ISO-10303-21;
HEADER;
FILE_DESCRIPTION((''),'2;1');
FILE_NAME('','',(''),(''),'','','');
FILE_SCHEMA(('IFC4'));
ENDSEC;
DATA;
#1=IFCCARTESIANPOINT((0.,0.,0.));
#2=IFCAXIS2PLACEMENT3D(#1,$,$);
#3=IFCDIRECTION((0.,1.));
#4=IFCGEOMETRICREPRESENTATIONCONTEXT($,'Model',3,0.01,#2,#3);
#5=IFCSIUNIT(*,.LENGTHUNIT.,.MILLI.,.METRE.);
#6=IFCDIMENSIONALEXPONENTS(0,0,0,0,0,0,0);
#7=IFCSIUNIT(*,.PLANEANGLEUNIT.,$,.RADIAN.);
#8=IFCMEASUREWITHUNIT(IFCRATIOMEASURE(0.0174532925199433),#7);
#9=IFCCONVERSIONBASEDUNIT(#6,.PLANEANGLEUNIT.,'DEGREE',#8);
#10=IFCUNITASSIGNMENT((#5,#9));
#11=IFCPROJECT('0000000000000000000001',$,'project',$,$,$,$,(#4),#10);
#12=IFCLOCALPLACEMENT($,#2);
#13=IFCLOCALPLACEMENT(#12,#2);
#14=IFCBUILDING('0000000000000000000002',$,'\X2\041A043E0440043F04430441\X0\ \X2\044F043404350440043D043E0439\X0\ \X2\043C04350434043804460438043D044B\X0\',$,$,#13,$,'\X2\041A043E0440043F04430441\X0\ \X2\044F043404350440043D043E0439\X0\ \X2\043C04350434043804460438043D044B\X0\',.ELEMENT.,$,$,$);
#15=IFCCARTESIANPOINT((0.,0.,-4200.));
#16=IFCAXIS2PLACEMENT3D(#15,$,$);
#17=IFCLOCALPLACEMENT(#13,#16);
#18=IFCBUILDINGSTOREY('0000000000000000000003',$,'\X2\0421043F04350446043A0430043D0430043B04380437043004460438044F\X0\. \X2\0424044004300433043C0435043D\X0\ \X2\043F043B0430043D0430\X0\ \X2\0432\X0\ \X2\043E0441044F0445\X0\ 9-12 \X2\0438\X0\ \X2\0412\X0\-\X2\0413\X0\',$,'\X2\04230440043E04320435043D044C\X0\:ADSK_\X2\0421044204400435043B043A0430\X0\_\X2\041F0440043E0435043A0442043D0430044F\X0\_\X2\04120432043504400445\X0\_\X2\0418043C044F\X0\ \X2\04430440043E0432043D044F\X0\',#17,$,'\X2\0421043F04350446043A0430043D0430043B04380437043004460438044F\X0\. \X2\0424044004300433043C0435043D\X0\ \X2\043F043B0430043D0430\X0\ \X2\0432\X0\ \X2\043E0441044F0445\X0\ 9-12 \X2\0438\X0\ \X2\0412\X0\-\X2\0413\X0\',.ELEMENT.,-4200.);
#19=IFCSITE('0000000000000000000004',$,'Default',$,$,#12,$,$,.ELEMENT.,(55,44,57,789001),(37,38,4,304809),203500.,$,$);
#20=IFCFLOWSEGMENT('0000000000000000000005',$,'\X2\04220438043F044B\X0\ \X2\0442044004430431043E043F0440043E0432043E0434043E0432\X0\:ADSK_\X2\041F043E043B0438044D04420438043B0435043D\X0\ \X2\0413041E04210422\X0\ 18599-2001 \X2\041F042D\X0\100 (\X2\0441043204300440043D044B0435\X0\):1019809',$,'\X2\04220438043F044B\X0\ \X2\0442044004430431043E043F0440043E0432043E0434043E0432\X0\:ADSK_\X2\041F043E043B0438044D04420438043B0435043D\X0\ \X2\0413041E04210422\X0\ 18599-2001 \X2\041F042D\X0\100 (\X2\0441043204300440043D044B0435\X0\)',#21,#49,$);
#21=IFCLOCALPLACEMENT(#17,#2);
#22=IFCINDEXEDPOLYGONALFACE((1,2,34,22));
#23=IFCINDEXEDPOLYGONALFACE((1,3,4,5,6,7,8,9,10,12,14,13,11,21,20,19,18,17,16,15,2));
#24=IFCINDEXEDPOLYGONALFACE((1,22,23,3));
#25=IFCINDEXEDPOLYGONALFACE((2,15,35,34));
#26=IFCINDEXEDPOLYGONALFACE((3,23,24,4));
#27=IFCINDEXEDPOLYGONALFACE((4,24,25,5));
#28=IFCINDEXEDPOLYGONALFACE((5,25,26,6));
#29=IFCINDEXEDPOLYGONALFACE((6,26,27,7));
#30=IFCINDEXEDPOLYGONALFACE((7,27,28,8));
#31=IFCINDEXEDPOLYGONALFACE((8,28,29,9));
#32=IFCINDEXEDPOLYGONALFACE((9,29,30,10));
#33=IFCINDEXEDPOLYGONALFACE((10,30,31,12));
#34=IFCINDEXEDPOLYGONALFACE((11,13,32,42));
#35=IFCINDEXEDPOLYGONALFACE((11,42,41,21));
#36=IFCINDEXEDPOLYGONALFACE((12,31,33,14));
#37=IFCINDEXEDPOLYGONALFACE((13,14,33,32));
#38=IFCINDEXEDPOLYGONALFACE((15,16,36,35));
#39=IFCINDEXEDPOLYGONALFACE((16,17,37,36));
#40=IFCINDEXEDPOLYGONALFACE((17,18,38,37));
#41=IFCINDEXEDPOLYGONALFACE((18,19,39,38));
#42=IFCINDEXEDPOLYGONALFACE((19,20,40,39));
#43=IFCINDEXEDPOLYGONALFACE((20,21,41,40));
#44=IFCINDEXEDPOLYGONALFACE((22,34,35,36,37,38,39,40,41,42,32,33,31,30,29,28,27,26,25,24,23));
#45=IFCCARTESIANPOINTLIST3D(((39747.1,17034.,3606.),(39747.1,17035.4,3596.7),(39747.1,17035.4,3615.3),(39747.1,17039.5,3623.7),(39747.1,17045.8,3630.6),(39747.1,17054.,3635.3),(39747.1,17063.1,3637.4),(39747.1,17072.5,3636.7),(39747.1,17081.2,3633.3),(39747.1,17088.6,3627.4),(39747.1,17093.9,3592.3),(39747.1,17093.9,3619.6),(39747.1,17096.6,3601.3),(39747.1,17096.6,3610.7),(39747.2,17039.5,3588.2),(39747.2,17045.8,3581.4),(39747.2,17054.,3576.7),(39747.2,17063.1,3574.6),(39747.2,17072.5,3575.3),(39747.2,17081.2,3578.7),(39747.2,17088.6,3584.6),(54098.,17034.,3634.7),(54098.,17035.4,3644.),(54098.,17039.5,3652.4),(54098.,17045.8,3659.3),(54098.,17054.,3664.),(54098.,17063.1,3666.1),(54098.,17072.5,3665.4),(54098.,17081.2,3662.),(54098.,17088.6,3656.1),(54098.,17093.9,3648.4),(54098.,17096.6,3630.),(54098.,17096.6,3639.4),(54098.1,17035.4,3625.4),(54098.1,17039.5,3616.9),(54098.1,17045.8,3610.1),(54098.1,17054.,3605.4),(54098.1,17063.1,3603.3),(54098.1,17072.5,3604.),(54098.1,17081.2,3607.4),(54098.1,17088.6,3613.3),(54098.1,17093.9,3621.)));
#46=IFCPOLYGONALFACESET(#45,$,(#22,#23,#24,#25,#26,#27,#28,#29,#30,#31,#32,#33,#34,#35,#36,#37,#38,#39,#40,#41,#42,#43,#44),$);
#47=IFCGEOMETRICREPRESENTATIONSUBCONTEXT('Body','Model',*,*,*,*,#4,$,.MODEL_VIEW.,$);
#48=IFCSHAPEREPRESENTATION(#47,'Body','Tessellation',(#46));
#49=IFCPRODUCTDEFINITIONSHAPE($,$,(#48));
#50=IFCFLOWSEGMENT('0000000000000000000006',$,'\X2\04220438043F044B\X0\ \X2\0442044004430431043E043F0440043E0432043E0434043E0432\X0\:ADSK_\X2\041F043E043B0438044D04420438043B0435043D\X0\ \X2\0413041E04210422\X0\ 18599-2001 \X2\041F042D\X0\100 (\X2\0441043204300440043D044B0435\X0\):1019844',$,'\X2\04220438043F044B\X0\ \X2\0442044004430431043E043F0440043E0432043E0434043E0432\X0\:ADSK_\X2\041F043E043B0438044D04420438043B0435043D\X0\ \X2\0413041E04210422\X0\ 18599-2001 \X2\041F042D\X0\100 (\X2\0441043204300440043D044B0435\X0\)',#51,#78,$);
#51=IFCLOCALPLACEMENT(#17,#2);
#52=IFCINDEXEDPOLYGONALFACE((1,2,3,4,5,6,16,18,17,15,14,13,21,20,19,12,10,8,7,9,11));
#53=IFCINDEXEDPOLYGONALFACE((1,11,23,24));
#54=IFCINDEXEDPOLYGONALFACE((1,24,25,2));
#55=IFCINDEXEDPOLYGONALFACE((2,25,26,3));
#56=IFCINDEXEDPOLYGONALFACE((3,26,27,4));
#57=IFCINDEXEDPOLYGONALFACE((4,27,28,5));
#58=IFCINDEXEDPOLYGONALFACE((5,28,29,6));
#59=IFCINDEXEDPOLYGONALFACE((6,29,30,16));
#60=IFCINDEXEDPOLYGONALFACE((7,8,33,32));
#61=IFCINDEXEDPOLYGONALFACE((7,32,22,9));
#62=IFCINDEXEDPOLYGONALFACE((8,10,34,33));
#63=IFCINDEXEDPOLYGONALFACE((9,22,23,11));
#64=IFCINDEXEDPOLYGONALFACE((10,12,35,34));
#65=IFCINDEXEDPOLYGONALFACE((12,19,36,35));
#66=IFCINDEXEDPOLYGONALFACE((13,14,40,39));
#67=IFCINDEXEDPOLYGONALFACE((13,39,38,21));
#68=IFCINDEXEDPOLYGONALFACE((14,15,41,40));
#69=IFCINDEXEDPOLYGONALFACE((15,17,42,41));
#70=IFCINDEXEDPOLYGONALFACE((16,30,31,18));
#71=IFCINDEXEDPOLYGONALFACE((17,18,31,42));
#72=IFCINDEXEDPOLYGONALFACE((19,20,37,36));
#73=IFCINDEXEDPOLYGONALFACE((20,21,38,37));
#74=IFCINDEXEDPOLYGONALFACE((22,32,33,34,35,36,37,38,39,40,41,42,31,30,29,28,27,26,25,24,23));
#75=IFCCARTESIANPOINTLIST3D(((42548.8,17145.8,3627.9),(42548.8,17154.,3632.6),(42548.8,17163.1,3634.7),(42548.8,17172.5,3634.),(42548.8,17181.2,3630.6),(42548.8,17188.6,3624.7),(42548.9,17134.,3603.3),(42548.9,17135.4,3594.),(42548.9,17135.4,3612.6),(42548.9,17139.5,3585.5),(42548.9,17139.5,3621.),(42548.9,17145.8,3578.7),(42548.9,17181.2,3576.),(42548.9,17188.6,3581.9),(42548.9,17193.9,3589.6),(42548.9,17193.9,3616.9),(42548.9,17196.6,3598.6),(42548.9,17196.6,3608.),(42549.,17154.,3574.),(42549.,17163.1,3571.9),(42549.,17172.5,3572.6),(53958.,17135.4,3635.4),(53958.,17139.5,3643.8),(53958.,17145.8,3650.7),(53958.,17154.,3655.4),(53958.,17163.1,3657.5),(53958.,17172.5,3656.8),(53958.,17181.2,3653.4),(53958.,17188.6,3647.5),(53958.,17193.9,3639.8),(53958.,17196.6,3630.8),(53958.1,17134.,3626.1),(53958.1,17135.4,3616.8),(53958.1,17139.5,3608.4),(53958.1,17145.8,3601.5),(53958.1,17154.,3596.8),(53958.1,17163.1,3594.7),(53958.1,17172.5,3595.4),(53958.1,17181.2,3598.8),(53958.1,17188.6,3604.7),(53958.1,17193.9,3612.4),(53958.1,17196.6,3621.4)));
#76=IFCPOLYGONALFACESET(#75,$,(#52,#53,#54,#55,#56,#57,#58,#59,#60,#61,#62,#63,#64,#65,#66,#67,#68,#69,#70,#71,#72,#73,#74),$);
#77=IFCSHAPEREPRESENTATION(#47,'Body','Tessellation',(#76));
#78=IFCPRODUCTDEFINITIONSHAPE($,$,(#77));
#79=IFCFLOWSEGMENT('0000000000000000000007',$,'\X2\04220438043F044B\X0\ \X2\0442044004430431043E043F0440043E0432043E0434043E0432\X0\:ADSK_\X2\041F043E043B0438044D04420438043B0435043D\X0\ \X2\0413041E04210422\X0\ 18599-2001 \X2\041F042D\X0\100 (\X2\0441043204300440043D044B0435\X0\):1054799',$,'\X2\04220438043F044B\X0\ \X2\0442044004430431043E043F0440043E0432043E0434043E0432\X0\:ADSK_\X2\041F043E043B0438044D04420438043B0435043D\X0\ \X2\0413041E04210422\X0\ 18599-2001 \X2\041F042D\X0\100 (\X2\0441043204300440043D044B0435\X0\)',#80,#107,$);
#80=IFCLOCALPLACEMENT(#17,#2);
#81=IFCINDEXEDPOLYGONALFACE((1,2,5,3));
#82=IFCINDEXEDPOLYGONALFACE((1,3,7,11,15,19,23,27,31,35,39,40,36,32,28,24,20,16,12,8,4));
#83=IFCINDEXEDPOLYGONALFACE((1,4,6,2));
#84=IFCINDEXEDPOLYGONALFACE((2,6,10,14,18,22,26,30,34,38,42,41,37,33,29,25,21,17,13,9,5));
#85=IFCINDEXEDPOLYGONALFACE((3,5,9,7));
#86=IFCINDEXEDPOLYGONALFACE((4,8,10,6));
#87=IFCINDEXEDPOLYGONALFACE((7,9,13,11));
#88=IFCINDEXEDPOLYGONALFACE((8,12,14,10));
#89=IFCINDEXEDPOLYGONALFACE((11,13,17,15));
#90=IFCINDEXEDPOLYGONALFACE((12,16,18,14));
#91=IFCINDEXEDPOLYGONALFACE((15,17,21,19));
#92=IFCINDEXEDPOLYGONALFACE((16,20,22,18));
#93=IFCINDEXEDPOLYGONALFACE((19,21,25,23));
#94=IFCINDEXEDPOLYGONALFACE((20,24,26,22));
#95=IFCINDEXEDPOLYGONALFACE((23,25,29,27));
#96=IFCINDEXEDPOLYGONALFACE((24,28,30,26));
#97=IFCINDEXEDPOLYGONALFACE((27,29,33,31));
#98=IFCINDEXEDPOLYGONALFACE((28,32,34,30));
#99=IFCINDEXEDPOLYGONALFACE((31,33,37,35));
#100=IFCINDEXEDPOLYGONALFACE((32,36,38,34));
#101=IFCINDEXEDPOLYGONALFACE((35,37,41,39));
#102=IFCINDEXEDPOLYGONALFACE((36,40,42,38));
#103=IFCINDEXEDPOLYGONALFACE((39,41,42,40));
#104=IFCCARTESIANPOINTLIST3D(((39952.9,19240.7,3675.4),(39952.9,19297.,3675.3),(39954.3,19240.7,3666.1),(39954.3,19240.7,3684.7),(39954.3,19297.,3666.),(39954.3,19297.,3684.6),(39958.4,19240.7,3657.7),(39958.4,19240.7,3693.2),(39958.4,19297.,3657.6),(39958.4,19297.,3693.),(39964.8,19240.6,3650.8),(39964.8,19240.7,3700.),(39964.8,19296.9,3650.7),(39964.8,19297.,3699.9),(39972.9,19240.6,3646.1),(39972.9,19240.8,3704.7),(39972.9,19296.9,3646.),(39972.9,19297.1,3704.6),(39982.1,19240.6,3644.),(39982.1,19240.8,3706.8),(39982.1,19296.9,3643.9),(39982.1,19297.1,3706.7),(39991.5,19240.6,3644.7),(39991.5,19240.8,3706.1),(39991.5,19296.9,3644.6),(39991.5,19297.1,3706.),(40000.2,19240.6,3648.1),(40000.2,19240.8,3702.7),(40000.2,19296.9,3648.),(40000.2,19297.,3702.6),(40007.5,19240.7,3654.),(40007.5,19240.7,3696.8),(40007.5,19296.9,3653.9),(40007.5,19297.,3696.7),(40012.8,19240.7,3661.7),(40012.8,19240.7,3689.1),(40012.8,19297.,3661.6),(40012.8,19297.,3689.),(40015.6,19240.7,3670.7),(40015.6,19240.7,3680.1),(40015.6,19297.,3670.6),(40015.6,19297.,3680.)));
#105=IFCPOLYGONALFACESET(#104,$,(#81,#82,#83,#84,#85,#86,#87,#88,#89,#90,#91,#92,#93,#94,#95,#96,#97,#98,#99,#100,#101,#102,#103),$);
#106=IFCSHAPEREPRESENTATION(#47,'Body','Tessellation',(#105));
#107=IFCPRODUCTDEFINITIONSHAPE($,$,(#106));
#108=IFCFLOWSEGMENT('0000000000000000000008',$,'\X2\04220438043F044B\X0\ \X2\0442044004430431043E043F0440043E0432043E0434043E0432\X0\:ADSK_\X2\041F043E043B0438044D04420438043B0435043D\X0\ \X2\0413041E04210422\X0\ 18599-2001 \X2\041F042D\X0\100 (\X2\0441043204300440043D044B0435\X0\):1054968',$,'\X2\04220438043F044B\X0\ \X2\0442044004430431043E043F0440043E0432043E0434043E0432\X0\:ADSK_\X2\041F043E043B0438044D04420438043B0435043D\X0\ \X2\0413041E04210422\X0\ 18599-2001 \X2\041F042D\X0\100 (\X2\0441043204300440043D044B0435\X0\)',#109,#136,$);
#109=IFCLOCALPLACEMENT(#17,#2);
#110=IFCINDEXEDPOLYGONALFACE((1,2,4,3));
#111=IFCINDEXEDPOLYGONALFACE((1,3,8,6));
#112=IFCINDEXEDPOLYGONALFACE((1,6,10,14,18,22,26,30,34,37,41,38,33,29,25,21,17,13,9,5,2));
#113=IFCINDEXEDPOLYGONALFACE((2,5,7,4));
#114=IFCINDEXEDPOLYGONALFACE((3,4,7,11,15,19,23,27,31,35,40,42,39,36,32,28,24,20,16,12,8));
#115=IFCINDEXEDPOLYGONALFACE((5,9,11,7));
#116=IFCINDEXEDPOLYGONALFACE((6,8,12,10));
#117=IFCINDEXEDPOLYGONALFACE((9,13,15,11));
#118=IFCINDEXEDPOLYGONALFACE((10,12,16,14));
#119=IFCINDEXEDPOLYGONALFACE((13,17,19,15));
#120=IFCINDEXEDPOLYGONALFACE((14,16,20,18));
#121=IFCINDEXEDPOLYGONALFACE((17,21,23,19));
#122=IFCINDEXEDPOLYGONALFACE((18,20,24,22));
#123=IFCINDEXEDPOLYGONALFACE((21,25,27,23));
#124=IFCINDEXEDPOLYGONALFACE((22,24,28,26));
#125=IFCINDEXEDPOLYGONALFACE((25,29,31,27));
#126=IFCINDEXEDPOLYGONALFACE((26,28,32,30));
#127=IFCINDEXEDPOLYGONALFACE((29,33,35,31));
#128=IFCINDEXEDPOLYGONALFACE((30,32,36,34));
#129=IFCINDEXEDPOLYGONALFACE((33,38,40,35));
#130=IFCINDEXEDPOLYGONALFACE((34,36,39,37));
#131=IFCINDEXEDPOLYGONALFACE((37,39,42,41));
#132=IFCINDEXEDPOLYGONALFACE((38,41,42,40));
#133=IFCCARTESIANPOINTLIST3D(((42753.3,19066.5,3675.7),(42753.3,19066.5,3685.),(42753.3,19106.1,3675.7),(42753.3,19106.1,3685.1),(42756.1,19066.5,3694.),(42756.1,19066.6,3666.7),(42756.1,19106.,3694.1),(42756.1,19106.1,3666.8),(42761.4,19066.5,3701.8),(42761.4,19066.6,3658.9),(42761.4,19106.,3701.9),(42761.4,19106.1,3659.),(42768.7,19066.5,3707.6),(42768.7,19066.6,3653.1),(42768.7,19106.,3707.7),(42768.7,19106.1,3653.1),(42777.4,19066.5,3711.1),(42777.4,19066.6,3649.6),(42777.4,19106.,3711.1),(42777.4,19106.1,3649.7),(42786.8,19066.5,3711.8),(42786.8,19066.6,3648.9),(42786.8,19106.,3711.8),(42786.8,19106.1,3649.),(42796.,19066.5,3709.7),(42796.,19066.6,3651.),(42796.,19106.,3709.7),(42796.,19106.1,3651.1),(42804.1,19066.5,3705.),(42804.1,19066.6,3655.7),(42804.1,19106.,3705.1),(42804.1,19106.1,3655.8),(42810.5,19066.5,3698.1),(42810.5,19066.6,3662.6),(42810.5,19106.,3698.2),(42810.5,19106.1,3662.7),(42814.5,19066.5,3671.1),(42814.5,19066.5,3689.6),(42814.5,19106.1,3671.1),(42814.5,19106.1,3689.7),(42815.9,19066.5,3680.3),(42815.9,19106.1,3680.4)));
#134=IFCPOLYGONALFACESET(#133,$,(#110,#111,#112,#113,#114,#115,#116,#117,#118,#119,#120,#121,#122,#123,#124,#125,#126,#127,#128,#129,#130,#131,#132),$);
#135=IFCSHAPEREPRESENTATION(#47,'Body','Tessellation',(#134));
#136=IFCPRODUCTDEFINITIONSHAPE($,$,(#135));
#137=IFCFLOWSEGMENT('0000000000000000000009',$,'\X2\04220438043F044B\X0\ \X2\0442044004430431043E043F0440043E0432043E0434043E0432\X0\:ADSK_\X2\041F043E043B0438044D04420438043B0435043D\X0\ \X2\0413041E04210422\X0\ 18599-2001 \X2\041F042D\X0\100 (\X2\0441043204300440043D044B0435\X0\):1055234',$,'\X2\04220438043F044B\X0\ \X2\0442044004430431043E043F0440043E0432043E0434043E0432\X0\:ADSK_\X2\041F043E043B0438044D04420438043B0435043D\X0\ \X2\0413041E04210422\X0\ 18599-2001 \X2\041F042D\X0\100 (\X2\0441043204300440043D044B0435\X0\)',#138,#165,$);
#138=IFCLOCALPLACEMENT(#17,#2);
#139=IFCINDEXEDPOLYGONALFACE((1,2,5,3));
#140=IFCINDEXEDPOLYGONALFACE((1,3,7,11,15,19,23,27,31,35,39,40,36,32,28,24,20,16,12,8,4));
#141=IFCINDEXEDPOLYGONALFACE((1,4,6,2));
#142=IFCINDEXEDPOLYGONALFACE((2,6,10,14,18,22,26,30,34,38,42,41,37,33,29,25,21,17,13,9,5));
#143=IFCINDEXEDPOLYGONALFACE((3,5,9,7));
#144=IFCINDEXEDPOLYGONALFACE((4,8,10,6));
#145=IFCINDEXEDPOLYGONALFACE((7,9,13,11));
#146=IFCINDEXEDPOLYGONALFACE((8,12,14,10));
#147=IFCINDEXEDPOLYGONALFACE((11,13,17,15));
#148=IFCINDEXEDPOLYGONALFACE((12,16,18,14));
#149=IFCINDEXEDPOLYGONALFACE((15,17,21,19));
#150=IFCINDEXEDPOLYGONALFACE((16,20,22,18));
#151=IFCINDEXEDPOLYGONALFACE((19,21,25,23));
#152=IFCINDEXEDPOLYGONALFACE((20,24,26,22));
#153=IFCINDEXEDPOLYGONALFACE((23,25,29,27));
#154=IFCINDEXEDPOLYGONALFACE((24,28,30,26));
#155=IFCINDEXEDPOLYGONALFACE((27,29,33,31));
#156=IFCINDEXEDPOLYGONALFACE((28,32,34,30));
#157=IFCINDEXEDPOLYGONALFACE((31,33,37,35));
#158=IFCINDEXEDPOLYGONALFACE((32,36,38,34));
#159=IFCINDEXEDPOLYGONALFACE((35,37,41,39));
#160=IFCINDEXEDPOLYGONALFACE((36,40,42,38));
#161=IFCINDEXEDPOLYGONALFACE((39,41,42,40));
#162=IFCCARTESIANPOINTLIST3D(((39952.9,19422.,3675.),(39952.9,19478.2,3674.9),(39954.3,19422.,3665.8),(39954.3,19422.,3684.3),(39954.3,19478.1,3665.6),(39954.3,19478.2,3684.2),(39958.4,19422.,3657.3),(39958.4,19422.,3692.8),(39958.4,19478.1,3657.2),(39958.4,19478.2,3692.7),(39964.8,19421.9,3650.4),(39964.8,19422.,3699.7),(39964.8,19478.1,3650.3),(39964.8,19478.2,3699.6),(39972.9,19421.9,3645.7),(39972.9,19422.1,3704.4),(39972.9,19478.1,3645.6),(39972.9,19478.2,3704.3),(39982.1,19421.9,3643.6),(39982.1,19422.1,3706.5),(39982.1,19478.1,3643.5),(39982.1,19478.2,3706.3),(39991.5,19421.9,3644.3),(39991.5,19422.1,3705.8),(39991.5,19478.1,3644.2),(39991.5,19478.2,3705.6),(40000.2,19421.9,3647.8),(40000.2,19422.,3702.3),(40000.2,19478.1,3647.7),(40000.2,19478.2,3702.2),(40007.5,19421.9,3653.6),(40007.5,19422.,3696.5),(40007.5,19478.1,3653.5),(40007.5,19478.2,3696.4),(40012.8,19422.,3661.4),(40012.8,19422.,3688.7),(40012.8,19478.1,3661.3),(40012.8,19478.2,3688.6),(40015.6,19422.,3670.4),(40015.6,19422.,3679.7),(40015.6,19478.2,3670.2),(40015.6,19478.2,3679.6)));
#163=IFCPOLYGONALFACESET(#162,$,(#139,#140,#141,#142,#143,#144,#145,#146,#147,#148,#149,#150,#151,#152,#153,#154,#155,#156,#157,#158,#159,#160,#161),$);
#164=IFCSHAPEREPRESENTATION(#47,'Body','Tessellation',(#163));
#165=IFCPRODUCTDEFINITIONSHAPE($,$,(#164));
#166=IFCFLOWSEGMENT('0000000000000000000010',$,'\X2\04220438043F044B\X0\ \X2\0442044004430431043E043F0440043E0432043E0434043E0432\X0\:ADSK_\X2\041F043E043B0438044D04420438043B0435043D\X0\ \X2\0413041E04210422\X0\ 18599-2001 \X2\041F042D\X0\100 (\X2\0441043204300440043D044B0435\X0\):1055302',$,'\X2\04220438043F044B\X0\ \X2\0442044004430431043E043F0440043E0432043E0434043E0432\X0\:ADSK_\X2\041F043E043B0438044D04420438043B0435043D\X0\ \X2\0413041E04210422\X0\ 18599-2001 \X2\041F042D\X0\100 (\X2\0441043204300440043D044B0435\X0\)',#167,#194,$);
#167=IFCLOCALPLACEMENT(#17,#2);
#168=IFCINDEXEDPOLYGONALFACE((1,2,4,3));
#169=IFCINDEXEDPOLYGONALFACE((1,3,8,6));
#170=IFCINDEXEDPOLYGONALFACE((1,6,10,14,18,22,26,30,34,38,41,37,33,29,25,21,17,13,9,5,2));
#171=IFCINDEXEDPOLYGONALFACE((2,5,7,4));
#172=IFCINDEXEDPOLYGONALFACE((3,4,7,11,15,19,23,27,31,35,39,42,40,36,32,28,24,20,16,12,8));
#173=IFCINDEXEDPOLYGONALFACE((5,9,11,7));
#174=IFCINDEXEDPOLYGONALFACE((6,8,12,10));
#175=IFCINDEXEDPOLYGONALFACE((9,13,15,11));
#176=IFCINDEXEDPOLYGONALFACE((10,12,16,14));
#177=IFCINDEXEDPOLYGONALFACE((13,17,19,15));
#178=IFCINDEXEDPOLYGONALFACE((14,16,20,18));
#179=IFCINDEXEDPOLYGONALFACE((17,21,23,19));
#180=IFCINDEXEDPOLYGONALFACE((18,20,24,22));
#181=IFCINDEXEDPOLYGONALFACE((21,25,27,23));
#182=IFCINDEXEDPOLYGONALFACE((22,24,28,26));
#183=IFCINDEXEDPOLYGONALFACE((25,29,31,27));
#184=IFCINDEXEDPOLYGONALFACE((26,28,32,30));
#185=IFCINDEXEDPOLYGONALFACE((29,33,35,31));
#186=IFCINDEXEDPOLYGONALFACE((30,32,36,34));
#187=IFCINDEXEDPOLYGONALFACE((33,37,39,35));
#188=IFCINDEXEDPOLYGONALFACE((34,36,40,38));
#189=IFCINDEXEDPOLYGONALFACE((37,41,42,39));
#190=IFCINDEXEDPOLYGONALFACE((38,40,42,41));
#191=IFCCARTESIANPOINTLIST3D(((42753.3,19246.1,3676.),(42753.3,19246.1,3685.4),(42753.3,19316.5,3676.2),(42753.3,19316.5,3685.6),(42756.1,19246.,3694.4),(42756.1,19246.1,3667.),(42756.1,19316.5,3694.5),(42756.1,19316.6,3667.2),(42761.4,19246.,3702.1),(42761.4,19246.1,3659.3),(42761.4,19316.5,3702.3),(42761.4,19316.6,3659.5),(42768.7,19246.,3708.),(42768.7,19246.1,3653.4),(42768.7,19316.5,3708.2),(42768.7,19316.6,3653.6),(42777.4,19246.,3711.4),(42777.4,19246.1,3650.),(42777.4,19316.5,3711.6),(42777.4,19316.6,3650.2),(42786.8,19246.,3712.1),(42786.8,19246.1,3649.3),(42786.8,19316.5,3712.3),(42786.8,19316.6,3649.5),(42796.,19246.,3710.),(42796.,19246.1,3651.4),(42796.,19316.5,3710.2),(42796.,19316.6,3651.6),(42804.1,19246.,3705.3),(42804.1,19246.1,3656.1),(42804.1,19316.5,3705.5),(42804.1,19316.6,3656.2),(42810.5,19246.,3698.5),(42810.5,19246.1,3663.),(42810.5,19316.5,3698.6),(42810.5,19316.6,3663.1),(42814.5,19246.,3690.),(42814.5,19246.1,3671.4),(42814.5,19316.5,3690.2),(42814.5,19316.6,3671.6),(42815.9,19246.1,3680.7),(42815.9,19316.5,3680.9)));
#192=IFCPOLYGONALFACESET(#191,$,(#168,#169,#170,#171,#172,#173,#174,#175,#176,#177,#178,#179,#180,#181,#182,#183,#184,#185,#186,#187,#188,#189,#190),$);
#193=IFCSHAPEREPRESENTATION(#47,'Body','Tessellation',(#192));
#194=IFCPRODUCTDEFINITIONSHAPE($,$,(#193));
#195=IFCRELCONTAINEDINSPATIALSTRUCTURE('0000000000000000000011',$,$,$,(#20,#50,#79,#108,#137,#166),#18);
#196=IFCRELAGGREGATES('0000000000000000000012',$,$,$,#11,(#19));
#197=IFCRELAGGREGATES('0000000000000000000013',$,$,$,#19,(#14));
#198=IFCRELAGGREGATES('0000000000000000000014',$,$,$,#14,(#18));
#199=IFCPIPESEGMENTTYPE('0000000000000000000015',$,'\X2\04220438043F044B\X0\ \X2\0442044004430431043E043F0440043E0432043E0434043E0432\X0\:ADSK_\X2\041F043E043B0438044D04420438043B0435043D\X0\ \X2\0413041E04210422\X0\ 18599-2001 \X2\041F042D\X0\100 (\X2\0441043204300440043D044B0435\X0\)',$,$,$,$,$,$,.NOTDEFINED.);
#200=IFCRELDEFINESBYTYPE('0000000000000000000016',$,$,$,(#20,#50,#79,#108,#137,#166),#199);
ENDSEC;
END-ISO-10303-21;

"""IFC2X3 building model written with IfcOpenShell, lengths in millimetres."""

from ifc_helpers import new_model, entity, si_unit, converted_unit, direction, frame, frame_2d, origin, origin_2d_with_axis, place, context, subcontext, project, spatial, circle, extrude, type_object, element, save


model = new_model("IFC2X3")

# Units and contexts
model_context = context("Model", 3, precision=0.01, world=origin(), true_north=direction((0.0, 1.0)))
body_context = subcontext(model_context, "Body", "Model", "MODEL_VIEW")
ifc_project = project(units=[si_unit("LENGTHUNIT", "METRE", prefix="MILLI"), converted_unit("PLANEANGLEUNIT", "DEGREE", entity("IfcRatioMeasure", 0.0174532925199433), si_unit("PLANEANGLEUNIT", "RADIAN"), dimensions=[0, 0, 0, 0, 0, 0, 0])], contexts=[model_context])

# Site, building, storey
site_placement = place(None, frame((0.0, 0.0, 0.0)))
site = spatial("IfcSite", under=ifc_project, at=site_placement, Name="Default", CompositionType="ELEMENT", RefLatitude=(55, 44, 57, 789001), RefLongitude=(37, 38, 4, 304809), RefElevation=203500.0)
building_placement = place(site_placement, origin())
building = spatial("IfcBuilding", under=site, at=building_placement, Name="Корпус ядерной медицины", LongName="Корпус ядерной медицины", CompositionType="ELEMENT")
storey_placement = place(building_placement, frame((0.0, 0.0, -4200.0)))
storey = spatial("IfcBuildingStorey", under=building, at=storey_placement, Name="Спецканализация. Фрагмен плана в осях 9-12 и В-Г", ObjectType="Уровень:ADSK_Стрелка_Проектная_Вверх_Имя уровня", LongName="Спецканализация. Фрагмен плана в осях 9-12 и В-Г", CompositionType="ELEMENT", Elevation=-4200.0)

# Flow segments
pipe_segment_type = type_object("IfcPipeSegmentType", Name="Типы трубопроводов:ADSK_Полиэтилен ГОСТ 18599-2001 ПЭ100 (сварные)", PredefinedType="NOTDEFINED")
flow_segment_1_placement = place(storey_placement, frame((39747.1, 17032.4, 3572.9)))
element("IfcFlowSegment", 1, at=flow_segment_1_placement, inside=storey, type_object=pipe_segment_type, Name="Типы трубопроводов:ADSK_Полиэтилен ГОСТ 18599-2001 ПЭ100 (сварные):1019809", ObjectType="Типы трубопроводов:ADSK_Полиэтилен ГОСТ 18599-2001 ПЭ100 (сварные)", context=body_context, shape_type="SweptSolid", body=[
    extrude(circle(Radius=31.5, at=origin_2d_with_axis()), frame((0.1, 33.1, 33.1), z_axis=(0.999998, 0.0, 0.002), x_axis=(0.0, -1.0, 0.0)), (0.0, 0.0, 1.0), 14350.9),
])
flow_segment_2_placement = place(storey_placement, frame((42548.8, 17132.4, 3570.2)))
element("IfcFlowSegment", 2, at=flow_segment_2_placement, inside=storey, type_object=pipe_segment_type, Name="Типы трубопроводов:ADSK_Полиэтилен ГОСТ 18599-2001 ПЭ100 (сварные):1019844", ObjectType="Типы трубопроводов:ADSK_Полиэтилен ГОСТ 18599-2001 ПЭ100 (сварные)", context=body_context, shape_type="SweptSolid", body=[
    extrude(circle(Radius=31.5, at=origin_2d_with_axis()), frame((0.1, 33.1, 33.1), z_axis=(0.999998, 0.0, 0.002), x_axis=(0.0, -1.0, 0.0)), (0.0, 0.0, 1.0), 11409.2),
])
flow_segment_3_placement = place(storey_placement, frame((39951.3, 19240.6, 3642.2)))
element("IfcFlowSegment", 3, at=flow_segment_3_placement, inside=storey, type_object=pipe_segment_type, Name="Типы трубопроводов:ADSK_Полиэтилен ГОСТ 18599-2001 ПЭ100 (сварные):1054799", ObjectType="Типы трубопроводов:ADSK_Полиэтилен ГОСТ 18599-2001 ПЭ100 (сварные)", context=body_context, shape_type="SweptSolid", body=[
    extrude(circle(Radius=31.5, at=origin_2d_with_axis()), frame((33.1, 0.1, 33.2), z_axis=(0.000004, 0.999998, -0.002), x_axis=(-1.0, 0.000004, 0.0)), (0.0, 0.0, 1.0), 56.3),
])
flow_segment_4_placement = place(storey_placement, frame((42751.3, 19066.5, 3647.3)))
element("IfcFlowSegment", 4, at=flow_segment_4_placement, inside=storey, type_object=pipe_segment_type, Name="Типы трубопроводов:ADSK_Полиэтилен ГОСТ 18599-2001 ПЭ100 (сварные):1054968", ObjectType="Типы трубопроводов:ADSK_Полиэтилен ГОСТ 18599-2001 ПЭ100 (сварные)", context=body_context, shape_type="SweptSolid", body=[
    extrude(circle(Radius=31.5, at=origin_2d_with_axis()), frame((33.1, 0.1, 33.1), z_axis=(0.000001, 0.999998, 0.002), x_axis=(1.0, -0.000001, 0.0)), (0.0, 0.0, 1.0), 39.5),
])
flow_segment_5_placement = place(storey_placement, frame((39951.4, 19421.9, 3641.8)))
element("IfcFlowSegment", 5, at=flow_segment_5_placement, inside=storey, type_object=pipe_segment_type, Name="Типы трубопроводов:ADSK_Полиэтилен ГОСТ 18599-2001 ПЭ100 (сварные):1055234", ObjectType="Типы трубопроводов:ADSK_Полиэтилен ГОСТ 18599-2001 ПЭ100 (сварные)", context=body_context, shape_type="SweptSolid", body=[
    extrude(circle(Radius=31.5, at=frame_2d((0.0, 0.0), x_axis=(1.0, 0.0))), frame((33.1, 0.1, 33.2), z_axis=(0.000004, 0.999998, -0.002), x_axis=(-1.0, 0.000004, 0.0)), (0.0, 0.0, 1.0), 56.2),
])
flow_segment_6_placement = place(storey_placement, frame((42751.3, 19246.0, 3647.6)))
element("IfcFlowSegment", 6, at=flow_segment_6_placement, inside=storey, type_object=pipe_segment_type, Name="Типы трубопроводов:ADSK_Полиэтилен ГОСТ 18599-2001 ПЭ100 (сварные):1055302", ObjectType="Типы трубопроводов:ADSK_Полиэтилен ГОСТ 18599-2001 ПЭ100 (сварные)", context=body_context, shape_type="SweptSolid", body=[
    extrude(circle(Radius=31.5, at=frame_2d((0.0, 0.0), x_axis=(1.0, 0.0))), frame((33.1, 0.1, 33.1), z_axis=(0.000001, 0.999997, 0.002426), x_axis=(1.0, -0.000001, 0.0)), (0.0, 0.0, 1.0), 70.5),
])

save(model, "model.ifc")
